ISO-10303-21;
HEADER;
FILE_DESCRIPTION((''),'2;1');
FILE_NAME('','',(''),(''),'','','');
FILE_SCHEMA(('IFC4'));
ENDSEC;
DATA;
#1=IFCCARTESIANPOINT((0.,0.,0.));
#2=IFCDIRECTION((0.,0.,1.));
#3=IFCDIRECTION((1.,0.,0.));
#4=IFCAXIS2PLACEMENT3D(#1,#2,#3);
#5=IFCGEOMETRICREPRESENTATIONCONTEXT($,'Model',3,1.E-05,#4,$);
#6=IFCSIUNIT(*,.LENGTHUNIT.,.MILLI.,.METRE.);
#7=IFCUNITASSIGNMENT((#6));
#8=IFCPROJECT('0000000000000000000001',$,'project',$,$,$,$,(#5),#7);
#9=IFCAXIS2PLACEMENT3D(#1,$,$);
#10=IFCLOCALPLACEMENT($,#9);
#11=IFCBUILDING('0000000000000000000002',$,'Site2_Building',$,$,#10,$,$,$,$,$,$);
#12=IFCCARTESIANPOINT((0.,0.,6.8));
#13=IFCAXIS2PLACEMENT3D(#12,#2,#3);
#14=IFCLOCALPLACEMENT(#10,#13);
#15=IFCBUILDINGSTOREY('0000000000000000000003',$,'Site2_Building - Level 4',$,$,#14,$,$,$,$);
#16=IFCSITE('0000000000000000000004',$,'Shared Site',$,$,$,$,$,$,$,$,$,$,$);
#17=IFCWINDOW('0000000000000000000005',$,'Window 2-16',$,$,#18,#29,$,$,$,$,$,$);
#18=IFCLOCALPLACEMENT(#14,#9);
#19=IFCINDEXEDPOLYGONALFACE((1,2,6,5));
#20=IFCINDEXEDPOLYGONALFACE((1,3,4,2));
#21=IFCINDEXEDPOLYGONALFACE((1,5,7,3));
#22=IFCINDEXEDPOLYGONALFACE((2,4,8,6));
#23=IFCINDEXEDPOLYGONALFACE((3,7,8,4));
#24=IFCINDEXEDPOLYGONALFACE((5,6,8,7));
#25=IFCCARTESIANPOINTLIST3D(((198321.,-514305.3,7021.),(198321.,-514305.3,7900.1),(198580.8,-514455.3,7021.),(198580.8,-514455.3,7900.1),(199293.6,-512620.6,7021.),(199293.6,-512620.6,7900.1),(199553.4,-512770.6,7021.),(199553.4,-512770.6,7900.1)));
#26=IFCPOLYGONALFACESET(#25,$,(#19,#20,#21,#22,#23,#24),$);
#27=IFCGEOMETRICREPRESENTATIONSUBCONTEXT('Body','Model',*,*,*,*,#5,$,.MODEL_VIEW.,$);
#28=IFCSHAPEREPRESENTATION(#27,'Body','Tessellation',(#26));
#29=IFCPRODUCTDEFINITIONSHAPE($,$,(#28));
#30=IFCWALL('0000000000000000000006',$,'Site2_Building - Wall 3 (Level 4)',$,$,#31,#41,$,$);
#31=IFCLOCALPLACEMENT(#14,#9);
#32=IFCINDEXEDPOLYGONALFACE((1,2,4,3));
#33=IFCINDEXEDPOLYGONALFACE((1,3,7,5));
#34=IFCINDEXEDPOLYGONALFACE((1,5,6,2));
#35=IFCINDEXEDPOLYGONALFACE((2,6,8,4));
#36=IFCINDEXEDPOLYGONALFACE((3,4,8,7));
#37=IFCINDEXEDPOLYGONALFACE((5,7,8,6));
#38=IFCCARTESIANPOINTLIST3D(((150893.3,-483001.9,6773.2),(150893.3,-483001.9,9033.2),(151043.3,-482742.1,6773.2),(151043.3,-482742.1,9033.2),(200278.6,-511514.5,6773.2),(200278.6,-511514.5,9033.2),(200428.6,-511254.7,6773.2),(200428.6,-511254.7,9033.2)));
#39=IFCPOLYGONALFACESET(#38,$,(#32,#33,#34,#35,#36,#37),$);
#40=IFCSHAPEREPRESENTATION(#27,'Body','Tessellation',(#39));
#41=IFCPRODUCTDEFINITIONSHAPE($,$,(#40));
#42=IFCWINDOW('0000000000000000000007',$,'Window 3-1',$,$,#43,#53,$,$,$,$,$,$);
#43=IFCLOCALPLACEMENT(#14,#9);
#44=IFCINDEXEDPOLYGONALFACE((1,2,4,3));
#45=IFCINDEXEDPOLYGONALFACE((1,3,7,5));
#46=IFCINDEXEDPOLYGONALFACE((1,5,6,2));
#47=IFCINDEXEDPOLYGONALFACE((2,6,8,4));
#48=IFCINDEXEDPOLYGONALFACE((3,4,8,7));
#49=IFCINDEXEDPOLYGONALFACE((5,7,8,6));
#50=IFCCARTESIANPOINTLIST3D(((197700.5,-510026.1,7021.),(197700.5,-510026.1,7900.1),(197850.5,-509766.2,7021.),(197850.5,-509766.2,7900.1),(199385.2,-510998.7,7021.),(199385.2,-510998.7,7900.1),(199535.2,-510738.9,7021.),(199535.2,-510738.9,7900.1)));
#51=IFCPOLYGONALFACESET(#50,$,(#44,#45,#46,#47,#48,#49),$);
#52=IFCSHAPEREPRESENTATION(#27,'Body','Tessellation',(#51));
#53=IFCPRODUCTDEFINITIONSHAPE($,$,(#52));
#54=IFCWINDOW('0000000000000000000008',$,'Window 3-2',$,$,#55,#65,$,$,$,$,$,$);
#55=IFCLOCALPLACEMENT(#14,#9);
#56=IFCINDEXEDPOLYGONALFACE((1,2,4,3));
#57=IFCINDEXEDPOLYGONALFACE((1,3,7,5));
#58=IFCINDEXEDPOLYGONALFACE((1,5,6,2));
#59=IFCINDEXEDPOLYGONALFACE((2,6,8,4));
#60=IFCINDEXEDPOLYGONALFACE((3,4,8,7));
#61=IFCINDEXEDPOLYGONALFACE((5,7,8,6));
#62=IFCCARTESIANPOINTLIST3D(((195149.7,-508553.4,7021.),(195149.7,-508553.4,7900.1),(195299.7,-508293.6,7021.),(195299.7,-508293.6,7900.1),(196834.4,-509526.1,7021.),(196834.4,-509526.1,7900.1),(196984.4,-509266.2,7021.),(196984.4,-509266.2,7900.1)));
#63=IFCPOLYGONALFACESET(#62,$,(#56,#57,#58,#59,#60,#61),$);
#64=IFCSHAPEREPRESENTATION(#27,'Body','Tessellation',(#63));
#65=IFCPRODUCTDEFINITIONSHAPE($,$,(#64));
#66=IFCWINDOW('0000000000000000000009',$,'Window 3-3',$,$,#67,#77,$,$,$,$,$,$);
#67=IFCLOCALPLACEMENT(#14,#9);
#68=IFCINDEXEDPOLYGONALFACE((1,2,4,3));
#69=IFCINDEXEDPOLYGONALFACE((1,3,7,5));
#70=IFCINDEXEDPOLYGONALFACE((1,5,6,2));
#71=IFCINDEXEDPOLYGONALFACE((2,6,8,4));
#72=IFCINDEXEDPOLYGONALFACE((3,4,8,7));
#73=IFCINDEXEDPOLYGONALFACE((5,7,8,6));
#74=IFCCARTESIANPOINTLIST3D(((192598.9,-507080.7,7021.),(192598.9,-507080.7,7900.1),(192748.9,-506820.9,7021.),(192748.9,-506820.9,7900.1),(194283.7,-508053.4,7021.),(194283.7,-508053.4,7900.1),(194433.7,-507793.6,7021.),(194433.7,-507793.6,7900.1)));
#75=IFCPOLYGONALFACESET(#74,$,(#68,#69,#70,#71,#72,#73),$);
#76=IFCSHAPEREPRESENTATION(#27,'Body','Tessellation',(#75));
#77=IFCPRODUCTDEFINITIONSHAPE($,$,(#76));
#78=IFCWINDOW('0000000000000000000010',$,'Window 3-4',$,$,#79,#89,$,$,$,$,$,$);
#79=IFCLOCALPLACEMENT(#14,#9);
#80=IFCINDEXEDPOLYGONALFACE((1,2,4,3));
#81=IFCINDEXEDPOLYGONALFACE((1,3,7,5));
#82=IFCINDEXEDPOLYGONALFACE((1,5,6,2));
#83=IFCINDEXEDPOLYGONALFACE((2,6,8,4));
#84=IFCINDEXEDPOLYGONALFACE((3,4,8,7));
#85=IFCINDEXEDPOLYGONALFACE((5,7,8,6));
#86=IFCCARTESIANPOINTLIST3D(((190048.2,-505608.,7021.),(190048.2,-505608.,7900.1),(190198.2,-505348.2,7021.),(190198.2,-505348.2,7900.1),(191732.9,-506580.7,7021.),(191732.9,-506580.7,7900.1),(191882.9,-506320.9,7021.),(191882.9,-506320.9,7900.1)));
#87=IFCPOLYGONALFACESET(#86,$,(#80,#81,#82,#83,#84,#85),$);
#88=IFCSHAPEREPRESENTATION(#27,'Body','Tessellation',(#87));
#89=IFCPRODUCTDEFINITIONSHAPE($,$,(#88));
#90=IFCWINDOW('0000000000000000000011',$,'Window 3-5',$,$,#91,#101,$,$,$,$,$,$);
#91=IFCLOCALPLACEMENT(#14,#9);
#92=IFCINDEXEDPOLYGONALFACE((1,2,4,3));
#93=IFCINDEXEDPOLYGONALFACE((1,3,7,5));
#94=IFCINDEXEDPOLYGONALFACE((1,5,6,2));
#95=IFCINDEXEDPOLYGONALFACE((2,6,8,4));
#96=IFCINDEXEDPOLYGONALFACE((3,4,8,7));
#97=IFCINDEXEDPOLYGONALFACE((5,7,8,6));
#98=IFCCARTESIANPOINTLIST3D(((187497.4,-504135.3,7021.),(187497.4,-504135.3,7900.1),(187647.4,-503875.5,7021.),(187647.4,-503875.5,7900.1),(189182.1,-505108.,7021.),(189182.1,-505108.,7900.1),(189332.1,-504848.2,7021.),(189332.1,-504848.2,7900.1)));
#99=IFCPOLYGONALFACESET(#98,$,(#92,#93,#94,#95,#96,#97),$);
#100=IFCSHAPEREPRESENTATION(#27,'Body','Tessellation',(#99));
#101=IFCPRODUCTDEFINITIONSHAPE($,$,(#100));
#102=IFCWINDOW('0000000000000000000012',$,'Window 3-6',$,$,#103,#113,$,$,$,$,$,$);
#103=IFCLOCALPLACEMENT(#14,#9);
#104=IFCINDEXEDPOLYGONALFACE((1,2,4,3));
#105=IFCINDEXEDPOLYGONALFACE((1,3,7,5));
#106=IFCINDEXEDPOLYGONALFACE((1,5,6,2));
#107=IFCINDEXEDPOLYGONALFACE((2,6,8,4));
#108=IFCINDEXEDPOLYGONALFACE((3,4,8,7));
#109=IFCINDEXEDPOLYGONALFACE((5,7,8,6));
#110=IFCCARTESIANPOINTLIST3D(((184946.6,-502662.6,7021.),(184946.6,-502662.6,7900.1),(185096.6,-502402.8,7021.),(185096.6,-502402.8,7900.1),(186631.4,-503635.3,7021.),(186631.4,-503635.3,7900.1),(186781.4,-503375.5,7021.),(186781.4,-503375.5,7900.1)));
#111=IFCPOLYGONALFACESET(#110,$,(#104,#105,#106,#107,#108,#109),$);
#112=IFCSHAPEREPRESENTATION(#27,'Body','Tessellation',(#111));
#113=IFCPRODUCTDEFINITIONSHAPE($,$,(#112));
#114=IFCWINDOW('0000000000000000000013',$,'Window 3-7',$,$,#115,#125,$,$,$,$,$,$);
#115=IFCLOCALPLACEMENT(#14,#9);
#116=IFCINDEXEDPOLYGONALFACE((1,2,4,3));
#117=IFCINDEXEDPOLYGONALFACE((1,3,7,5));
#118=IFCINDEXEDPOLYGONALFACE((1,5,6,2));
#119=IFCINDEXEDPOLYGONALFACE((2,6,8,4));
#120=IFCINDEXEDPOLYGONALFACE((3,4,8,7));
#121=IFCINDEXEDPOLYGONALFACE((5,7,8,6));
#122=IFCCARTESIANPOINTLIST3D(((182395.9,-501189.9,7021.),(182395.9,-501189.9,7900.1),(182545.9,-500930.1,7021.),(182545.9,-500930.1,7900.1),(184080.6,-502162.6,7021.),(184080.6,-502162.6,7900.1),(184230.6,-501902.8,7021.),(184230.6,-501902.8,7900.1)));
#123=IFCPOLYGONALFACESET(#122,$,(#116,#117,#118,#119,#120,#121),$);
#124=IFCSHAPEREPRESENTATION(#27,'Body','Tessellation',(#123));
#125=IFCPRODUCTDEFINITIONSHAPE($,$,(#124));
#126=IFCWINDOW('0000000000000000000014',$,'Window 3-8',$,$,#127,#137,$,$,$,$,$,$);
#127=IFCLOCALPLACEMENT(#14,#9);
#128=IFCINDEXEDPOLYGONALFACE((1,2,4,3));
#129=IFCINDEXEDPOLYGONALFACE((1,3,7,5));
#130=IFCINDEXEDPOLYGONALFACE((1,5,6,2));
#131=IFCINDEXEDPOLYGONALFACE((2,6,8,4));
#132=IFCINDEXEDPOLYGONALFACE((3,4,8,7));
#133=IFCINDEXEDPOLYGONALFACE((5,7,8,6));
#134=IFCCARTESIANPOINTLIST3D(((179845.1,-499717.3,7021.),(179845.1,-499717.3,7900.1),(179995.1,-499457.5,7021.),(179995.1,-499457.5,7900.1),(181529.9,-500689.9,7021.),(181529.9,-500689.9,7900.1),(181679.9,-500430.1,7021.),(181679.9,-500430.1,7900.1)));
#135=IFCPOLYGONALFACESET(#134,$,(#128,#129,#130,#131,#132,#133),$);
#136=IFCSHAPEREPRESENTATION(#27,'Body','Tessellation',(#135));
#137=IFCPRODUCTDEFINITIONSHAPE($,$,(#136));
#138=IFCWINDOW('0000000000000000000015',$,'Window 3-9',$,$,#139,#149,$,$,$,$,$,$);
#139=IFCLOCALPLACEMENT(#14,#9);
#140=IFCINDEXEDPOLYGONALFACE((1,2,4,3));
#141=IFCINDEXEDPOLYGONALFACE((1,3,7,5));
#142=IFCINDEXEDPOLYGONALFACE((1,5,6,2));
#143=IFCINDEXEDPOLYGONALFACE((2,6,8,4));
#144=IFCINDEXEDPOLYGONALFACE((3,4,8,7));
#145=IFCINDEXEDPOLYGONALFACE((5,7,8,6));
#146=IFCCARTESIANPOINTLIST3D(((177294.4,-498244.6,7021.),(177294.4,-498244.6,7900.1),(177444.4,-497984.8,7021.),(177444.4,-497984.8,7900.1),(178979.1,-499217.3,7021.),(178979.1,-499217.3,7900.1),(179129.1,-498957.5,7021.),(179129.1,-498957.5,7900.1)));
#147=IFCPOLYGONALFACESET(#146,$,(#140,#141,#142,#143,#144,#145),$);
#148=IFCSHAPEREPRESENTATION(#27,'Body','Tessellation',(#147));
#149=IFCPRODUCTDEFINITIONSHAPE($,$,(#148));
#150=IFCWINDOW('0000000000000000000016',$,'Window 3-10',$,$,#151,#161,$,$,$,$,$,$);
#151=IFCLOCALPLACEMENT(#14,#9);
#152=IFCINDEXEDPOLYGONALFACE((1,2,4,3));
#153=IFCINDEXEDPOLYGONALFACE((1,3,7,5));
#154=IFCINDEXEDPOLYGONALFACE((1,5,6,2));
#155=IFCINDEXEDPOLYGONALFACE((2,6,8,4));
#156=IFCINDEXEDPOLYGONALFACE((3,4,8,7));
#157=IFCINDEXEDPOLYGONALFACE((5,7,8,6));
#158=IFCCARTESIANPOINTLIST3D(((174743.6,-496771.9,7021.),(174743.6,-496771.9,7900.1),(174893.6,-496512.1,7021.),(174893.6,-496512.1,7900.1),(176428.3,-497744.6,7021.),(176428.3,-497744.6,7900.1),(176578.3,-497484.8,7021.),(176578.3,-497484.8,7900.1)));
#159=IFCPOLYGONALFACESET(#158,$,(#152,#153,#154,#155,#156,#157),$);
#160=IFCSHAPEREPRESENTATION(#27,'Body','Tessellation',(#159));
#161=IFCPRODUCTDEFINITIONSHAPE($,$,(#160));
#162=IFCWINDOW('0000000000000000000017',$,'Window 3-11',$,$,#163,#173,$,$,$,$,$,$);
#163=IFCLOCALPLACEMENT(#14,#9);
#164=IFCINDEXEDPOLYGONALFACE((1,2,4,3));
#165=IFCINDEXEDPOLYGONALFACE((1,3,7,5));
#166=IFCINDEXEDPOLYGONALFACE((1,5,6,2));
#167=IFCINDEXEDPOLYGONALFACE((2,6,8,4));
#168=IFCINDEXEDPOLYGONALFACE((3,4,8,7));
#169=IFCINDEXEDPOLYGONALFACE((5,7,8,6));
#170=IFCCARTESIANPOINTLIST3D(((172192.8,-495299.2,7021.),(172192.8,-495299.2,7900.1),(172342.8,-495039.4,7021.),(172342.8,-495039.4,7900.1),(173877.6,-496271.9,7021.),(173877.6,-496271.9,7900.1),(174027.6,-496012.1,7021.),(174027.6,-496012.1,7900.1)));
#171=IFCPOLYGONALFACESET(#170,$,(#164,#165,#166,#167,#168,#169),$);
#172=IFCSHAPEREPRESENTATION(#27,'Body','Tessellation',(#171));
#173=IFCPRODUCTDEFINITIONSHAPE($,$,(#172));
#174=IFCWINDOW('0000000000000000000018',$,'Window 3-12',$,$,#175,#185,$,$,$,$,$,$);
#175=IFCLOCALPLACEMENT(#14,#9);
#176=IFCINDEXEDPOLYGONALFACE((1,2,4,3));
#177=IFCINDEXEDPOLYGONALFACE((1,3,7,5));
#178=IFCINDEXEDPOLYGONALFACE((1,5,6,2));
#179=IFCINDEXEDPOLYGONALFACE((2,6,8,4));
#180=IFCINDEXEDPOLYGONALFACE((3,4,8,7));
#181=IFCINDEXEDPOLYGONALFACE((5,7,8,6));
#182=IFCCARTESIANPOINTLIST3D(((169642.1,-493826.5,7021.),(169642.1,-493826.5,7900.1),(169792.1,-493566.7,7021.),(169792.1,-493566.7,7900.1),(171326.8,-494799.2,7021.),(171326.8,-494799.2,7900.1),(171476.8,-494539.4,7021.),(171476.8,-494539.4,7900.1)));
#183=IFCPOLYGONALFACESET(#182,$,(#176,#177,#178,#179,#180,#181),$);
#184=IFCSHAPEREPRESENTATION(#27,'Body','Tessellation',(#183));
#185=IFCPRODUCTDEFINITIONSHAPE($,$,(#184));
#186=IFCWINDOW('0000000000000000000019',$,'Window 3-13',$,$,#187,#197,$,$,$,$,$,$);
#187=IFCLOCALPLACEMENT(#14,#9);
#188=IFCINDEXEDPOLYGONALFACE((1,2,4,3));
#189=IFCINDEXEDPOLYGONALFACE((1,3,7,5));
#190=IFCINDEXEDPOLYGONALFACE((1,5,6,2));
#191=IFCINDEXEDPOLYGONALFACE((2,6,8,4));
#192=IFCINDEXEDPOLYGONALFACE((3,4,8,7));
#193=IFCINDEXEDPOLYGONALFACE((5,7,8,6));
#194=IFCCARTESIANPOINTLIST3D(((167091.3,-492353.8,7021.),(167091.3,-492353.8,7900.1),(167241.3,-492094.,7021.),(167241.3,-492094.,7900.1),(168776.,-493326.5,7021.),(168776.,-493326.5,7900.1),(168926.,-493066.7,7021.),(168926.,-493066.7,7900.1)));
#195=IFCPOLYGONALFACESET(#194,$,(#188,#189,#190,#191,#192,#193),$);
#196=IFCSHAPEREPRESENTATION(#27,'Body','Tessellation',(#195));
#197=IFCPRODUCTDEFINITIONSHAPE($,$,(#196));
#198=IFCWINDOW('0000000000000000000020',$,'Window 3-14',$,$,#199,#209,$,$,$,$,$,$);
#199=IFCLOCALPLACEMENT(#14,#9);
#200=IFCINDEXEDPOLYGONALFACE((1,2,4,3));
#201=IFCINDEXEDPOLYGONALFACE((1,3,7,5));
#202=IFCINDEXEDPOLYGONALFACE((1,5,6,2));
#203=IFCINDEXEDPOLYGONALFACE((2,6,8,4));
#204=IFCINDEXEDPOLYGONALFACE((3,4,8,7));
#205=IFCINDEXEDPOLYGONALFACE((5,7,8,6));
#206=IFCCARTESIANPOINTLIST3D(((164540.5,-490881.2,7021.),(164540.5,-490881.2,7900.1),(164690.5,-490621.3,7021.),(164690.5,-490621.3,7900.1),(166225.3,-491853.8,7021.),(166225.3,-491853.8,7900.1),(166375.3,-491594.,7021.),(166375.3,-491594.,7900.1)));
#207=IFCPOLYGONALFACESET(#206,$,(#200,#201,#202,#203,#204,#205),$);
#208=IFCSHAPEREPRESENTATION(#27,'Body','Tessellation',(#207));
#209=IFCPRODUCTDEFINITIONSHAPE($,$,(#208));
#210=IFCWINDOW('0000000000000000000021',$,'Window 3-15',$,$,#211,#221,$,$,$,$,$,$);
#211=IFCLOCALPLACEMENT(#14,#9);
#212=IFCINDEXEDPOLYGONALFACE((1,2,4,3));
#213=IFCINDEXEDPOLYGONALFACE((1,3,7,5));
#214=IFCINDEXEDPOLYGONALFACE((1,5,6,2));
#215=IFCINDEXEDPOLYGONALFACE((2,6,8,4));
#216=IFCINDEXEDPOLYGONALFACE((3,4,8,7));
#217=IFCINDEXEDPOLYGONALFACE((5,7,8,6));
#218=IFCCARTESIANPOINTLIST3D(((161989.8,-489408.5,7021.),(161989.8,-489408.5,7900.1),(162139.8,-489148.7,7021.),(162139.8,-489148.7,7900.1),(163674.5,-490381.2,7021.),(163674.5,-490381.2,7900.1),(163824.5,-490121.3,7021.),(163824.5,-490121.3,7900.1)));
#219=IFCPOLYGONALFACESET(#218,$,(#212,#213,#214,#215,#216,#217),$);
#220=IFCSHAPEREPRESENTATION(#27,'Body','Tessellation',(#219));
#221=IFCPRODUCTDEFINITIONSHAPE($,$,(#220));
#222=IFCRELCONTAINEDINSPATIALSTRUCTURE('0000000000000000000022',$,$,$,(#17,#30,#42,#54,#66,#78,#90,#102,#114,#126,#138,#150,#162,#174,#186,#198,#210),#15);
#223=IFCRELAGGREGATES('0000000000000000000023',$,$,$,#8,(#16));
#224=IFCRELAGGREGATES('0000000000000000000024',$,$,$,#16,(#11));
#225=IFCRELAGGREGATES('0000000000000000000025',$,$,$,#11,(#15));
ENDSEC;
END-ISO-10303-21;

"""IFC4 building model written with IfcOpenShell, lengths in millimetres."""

from ifc_helpers import new_model, si_unit, frame, origin, origin_with_axes, place, context, subcontext, project, spatial, indexed_curve, outline, extrude, element, save


model = new_model("IFC4")

# Units and contexts
model_context = context("Model", 3, precision=1e-05, world=origin_with_axes())
body_context = subcontext(model_context, "Body", "Model", "MODEL_VIEW")
ifc_project = project(units=[si_unit("LENGTHUNIT", "METRE", prefix="MILLI")], contexts=[model_context])

# Site, building, storey
site = spatial("IfcSite", under=ifc_project, Name="Shared Site")
building_placement = place(None, origin())
building = spatial("IfcBuilding", under=site, at=building_placement, Name="Site2_Building")
storey_placement = place(building_placement, frame((0.0, 0.0, 6.8), z_axis=(0.0, 0.0, 1.0), x_axis=(1.0, 0.0, 0.0)))
storey = spatial("IfcBuildingStorey", under=building, at=storey_placement, Name="Site2_Building - Level 4")

# Window
for number, where, z_axis, x_axis, name in (
    (1, (198580.8, -514455.3, 7021.0), (0.0, 0.0, 1.0), (0.5, 0.866025, 0.0), "Window 2-16"),
):
    element("IfcWindow", number, at=place(storey_placement, frame(where, z_axis=z_axis, x_axis=x_axis)), inside=storey, Name=name, context=body_context, shape_type="SweptSolid", body=[
        extrude(outline(indexed_curve([(0.0, 0.0), (0.0, 300.0), (1945.4, 300.0), (1945.4, 0.0), (0.0, 0.0)], self_intersect=False)), origin_with_axes(), (0.0, 0.0, 1.0), 879.1),
    ])

# Wall
wall_1_placement = place(storey_placement, frame((200428.6, -511254.7, 6773.2), z_axis=(0.0, 0.0, 1.0), x_axis=(-0.866025, 0.5, 0.0)))
element("IfcWall", 2, at=wall_1_placement, inside=storey, Name="Site2_Building - Wall 3 (Level 4)", context=body_context, shape_type="SweptSolid", body=[
    extrude(outline(indexed_curve([(0.0, 0.0), (0.0, 300.0), (57025.3, 300.0), (57025.3, 0.0), (0.0, 0.0)], self_intersect=False)), origin_with_axes(), (0.0, 0.0, 1.0), 2260.0),
])

# Windows
for number, where, z_axis, x_axis, name in (
    (3, (199535.2, -510738.9, 7021.0), (0.0, 0.0, 1.0), (-0.866025, 0.5, 0.0), "Window 3-1"),
    (4, (196984.4, -509266.2, 7021.0), (0.0, 0.0, 1.0), (-0.866025, 0.5, 0.0), "Window 3-2"),
    (5, (194433.7, -507793.6, 7021.0), (0.0, 0.0, 1.0), (-0.866025, 0.5, 0.0), "Window 3-3"),
    (6, (191882.9, -506320.9, 7021.0), (0.0, 0.0, 1.0), (-0.866025, 0.5, 0.0), "Window 3-4"),
    (7, (189332.1, -504848.2, 7021.0), (0.0, 0.0, 1.0), (-0.866025, 0.5, 0.0), "Window 3-5"),
    (8, (186781.4, -503375.5, 7021.0), (0.0, 0.0, 1.0), (-0.866025, 0.5, 0.0), "Window 3-6"),
    (9, (184230.6, -501902.8, 7021.0), (0.0, 0.0, 1.0), (-0.866025, 0.5, 0.0), "Window 3-7"),
    (10, (181679.9, -500430.1, 7021.0), (0.0, 0.0, 1.0), (-0.866025, 0.5, 0.0), "Window 3-8"),
    (11, (179129.1, -498957.5, 7021.0), (0.0, 0.0, 1.0), (-0.866025, 0.5, 0.0), "Window 3-9"),
    (12, (176578.3, -497484.8, 7021.0), (0.0, 0.0, 1.0), (-0.866025, 0.5, 0.0), "Window 3-10"),
    (13, (174027.6, -496012.1, 7021.0), (0.0, 0.0, 1.0), (-0.866025, 0.5, 0.0), "Window 3-11"),
    (14, (171476.8, -494539.4, 7021.0), (0.0, 0.0, 1.0), (-0.866025, 0.5, 0.0), "Window 3-12"),
    (15, (168926.0, -493066.7, 7021.0), (0.0, 0.0, 1.0), (-0.866025, 0.5, 0.0), "Window 3-13"),
    (16, (166375.3, -491594.0, 7021.0), (0.0, 0.0, 1.0), (-0.866025, 0.5, 0.0), "Window 3-14"),
    (17, (163824.5, -490121.3, 7021.0), (0.0, 0.0, 1.0), (-0.866025, 0.5, 0.0), "Window 3-15"),
):
    element("IfcWindow", number, at=place(storey_placement, frame(where, z_axis=z_axis, x_axis=x_axis)), inside=storey, Name=name, context=body_context, shape_type="SweptSolid", body=[
        extrude(outline(indexed_curve([(0.0, 0.0), (0.0, 300.0), (1945.4, 300.0), (1945.4, 0.0), (0.0, 0.0)], self_intersect=False)), origin_with_axes(), (0.0, 0.0, 1.0), 879.1),
    ])

save(model, "model.ifc")
